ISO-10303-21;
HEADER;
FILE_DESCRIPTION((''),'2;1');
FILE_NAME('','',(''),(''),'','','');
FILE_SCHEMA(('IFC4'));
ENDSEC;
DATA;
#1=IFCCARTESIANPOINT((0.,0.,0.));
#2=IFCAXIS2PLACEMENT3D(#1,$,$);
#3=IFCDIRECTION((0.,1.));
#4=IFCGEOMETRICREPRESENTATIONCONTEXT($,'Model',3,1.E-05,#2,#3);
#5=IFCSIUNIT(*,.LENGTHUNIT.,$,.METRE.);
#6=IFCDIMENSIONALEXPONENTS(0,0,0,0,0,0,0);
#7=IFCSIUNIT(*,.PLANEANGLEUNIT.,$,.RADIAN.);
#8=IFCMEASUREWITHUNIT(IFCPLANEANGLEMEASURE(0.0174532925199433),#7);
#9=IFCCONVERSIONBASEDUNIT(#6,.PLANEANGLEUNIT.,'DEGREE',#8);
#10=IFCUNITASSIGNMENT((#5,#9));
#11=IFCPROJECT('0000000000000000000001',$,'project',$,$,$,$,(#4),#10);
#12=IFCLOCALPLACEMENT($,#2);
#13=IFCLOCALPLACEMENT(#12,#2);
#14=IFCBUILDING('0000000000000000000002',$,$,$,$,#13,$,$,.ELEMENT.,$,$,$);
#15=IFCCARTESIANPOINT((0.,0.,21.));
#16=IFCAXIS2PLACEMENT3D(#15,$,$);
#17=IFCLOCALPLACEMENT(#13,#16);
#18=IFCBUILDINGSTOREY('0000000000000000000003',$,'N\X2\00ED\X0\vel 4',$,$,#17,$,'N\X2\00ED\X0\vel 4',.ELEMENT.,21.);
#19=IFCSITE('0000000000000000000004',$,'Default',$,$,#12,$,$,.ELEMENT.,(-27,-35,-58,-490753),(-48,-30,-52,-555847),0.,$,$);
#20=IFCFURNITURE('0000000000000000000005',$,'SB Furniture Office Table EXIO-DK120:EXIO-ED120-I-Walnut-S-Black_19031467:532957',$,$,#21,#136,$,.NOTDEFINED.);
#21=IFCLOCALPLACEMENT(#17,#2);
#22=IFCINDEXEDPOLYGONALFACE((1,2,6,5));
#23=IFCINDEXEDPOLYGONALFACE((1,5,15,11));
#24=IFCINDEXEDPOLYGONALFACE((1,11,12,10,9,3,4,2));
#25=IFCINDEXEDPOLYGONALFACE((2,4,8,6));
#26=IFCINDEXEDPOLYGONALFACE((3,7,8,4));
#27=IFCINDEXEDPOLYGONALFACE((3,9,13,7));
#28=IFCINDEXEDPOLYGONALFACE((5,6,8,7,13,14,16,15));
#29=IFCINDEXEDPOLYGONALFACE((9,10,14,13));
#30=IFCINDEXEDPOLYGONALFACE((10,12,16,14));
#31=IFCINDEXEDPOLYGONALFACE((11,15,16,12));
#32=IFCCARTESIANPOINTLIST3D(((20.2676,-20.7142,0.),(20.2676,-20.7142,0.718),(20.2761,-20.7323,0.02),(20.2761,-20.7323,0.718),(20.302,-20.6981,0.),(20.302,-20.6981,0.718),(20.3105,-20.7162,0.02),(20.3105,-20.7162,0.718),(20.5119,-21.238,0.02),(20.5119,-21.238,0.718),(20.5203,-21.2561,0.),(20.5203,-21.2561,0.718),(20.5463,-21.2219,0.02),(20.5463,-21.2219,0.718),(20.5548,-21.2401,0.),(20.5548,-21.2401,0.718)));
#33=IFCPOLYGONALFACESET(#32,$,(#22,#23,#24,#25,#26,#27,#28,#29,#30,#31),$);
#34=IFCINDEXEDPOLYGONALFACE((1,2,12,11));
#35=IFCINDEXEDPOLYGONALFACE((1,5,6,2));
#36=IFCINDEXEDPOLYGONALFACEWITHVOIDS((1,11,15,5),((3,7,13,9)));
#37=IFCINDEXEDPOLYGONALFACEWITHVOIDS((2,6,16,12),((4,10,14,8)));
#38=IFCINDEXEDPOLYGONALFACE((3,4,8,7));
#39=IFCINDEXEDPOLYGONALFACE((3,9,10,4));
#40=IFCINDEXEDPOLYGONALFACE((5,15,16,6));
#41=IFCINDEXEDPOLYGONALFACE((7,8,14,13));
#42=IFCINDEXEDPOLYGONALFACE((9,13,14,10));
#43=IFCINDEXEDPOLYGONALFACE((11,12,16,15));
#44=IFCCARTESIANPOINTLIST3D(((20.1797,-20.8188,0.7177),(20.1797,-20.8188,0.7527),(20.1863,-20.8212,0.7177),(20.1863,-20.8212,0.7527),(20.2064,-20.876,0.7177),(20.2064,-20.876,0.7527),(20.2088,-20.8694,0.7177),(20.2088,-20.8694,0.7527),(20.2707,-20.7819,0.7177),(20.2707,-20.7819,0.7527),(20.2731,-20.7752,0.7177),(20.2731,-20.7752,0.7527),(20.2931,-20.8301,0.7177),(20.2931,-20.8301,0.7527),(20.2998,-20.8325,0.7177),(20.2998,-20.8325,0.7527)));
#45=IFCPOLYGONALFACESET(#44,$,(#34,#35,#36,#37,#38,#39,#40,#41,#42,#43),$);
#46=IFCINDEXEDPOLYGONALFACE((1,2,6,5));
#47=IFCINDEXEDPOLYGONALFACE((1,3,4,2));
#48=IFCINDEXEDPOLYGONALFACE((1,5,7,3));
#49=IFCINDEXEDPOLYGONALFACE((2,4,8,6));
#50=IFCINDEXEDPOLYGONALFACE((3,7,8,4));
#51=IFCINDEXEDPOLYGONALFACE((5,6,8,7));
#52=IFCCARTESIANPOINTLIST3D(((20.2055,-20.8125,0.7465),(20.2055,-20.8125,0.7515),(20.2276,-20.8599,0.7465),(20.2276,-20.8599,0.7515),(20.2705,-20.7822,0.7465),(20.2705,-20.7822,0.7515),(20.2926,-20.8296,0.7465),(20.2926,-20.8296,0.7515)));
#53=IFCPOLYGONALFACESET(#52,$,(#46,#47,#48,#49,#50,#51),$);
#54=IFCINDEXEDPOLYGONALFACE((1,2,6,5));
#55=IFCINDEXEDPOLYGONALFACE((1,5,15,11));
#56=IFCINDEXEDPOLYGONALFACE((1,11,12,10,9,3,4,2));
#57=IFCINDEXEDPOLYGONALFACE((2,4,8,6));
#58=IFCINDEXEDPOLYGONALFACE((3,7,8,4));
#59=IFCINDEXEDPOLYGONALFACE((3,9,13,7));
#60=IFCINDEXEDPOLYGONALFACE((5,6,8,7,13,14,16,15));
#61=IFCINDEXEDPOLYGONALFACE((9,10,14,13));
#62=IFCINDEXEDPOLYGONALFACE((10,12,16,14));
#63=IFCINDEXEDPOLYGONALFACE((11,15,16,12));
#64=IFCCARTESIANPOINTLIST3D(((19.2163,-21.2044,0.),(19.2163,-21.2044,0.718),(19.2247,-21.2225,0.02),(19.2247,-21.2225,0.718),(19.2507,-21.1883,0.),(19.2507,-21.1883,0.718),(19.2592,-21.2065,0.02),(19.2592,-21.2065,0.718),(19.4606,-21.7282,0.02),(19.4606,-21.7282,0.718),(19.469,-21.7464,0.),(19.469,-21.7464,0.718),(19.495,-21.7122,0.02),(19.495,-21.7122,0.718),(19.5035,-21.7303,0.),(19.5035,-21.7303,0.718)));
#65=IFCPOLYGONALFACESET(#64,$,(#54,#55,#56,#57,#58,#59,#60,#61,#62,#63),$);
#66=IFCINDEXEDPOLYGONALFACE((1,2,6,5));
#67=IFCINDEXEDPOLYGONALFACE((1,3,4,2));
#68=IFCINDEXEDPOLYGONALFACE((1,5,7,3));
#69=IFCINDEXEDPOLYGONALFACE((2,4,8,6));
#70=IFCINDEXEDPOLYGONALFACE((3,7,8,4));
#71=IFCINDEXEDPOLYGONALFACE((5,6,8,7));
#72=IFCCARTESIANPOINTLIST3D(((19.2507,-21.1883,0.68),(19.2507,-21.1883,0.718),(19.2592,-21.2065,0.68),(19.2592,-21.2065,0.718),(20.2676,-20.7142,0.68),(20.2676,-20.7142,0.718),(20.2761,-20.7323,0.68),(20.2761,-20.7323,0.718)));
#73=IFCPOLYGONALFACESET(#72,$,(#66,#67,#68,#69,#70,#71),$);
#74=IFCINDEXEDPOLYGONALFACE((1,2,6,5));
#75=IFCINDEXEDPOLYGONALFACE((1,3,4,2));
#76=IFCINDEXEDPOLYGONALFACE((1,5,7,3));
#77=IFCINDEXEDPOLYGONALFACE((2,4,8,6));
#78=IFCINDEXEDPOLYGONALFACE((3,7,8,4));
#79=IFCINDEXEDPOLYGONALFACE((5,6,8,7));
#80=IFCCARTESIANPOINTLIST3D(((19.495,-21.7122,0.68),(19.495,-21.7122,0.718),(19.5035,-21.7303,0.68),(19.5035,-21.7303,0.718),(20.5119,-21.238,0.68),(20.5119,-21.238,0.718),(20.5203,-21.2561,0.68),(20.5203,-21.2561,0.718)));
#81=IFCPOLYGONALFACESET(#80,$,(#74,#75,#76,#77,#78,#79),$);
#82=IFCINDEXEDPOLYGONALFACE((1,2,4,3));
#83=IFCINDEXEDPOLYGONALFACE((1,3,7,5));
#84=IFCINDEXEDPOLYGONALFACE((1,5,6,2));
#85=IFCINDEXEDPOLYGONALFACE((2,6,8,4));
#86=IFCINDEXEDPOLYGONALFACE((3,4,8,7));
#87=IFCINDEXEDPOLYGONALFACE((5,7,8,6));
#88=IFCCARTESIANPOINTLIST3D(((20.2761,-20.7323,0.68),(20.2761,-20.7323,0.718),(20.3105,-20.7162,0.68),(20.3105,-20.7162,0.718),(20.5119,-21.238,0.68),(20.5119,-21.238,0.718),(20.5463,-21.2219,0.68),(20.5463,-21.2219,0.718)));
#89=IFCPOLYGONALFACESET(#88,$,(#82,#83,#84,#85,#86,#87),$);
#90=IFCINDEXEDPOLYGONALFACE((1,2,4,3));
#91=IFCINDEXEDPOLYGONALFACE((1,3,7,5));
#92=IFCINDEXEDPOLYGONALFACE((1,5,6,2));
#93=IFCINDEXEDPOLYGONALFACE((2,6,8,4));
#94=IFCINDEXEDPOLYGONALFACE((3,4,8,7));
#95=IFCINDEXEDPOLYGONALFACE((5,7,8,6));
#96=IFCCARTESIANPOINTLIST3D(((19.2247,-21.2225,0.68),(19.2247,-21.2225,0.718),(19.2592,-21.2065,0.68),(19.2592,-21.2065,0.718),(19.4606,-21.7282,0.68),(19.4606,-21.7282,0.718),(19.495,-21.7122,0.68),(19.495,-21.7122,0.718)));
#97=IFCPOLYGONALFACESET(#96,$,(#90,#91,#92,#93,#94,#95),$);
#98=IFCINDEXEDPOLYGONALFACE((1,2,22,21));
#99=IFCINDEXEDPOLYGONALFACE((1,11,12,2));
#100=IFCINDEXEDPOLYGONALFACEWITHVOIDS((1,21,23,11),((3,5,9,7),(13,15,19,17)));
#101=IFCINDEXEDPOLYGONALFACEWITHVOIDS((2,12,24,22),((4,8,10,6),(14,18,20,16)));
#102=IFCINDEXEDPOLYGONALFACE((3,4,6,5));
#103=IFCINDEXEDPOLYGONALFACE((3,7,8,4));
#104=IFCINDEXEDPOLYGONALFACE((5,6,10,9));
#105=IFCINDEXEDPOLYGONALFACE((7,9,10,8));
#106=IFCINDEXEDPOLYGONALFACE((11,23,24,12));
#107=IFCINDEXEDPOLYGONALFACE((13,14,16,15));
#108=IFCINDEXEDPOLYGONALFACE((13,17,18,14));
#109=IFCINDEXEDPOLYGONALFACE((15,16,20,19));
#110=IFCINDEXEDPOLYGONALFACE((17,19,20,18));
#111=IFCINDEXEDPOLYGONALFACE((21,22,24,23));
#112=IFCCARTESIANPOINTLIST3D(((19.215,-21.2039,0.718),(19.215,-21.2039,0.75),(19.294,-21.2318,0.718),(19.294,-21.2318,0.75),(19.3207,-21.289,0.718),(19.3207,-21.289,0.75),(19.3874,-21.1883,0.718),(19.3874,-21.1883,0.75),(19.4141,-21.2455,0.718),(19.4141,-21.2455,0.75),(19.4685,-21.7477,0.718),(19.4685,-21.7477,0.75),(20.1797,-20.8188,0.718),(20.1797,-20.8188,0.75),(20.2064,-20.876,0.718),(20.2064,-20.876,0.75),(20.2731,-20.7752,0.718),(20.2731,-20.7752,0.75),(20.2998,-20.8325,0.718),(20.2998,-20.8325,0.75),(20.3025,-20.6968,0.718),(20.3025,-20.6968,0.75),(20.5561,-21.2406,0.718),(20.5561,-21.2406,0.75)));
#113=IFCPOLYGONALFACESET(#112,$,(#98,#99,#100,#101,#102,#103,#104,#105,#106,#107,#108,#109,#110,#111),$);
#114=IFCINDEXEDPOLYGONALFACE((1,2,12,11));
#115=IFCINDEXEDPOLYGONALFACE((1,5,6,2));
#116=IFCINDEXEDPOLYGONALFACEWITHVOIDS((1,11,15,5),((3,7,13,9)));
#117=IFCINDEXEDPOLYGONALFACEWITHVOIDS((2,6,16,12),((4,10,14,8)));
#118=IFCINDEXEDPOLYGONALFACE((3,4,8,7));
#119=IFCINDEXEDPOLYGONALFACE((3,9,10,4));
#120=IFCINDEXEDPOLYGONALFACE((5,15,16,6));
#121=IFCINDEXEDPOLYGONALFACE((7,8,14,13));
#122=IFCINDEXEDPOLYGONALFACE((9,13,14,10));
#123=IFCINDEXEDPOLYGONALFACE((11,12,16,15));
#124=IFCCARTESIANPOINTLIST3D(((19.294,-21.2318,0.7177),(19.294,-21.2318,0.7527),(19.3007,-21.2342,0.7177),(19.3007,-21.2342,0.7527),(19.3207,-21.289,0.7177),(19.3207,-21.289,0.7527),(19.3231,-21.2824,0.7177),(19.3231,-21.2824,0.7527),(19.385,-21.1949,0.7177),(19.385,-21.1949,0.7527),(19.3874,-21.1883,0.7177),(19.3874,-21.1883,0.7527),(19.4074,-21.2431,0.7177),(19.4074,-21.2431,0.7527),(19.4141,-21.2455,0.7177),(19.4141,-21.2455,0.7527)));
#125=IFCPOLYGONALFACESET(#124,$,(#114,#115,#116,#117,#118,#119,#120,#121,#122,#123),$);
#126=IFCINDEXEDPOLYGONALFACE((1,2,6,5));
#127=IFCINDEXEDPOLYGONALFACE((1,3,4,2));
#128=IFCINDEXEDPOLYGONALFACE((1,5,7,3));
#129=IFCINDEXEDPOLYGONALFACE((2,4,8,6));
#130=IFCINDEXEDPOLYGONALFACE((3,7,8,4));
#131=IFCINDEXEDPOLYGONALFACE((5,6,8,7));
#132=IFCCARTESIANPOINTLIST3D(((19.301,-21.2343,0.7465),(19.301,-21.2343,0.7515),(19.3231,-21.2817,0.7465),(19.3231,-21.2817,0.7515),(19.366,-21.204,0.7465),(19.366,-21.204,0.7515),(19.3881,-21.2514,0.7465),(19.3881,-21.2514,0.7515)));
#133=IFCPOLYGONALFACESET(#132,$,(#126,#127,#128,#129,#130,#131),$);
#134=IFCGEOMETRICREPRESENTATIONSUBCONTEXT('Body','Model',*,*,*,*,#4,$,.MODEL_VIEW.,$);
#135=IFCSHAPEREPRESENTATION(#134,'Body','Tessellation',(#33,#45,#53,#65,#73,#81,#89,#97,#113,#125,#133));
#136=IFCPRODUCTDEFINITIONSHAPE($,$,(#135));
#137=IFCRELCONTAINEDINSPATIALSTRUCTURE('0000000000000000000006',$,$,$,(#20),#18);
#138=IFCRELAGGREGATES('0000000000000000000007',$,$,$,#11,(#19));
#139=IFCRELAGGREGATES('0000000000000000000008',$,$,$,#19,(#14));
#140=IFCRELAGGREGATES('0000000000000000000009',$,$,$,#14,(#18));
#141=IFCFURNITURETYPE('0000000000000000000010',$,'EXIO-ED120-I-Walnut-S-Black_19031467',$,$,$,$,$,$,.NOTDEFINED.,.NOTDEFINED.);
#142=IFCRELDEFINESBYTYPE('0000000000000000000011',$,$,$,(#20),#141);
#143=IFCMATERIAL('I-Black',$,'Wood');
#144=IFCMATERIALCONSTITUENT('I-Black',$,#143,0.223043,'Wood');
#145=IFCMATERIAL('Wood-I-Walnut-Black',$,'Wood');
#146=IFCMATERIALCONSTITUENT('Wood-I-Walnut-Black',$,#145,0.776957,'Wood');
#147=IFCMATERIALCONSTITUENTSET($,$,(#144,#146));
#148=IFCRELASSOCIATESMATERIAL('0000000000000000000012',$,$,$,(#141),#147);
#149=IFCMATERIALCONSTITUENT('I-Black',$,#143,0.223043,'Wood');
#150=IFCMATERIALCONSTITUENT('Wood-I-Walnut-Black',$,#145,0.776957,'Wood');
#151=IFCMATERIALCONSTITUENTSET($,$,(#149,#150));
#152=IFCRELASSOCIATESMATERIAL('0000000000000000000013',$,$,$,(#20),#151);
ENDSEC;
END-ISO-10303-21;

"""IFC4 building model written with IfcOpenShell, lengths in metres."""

from ifc_helpers import new_model, entity, si_unit, converted_unit, direction, frame, frame_2d, origin, origin_2d_with_axis, place, context, subcontext, project, spatial, polyline, rectangle, outline, extrude, source, transform, mapped, material, constituent, constituent_set, type_object, type_shapes, element, save


model = new_model("IFC4")

# Units and contexts
model_context = context("Model", 3, precision=1e-05, world=origin(), true_north=direction((0.0, 1.0)))
body_context = subcontext(model_context, "Body", "Model", "MODEL_VIEW")
ifc_project = project(units=[si_unit("LENGTHUNIT", "METRE"), converted_unit("PLANEANGLEUNIT", "DEGREE", entity("IfcPlaneAngleMeasure", 0.0174532925199433), si_unit("PLANEANGLEUNIT", "RADIAN"), dimensions=[0, 0, 0, 0, 0, 0, 0])], contexts=[model_context])

# Site, building, storey
site_placement = place(None, origin())
site = spatial("IfcSite", under=ifc_project, at=site_placement, Name="Default", CompositionType="ELEMENT", RefLatitude=(-27, -35, -58, -490753), RefLongitude=(-48, -30, -52, -555847), RefElevation=0.0)
building_placement = place(site_placement, origin())
building = spatial("IfcBuilding", under=site, at=building_placement, CompositionType="ELEMENT")
storey_placement = place(building_placement, frame((0.0, 0.0, 21.0)))
storey = spatial("IfcBuildingStorey", under=building, at=storey_placement, Name="Nível 4", LongName="Nível 4", CompositionType="ELEMENT", Elevation=21.0)

# Furniture
ifc_material_1 = material(Name="I-Black", Category="Wood")
ifc_constituent_1 = constituent(ifc_material_1, Name="I-Black", Category="Wood", fraction=0.223043)
ifc_material_2 = material(Name="Wood-I-Walnut-Black", Category="Wood")
ifc_constituent_2 = constituent(ifc_material_2, Name="Wood-I-Walnut-Black", Category="Wood", fraction=0.776957)
ifc_constituent_set_1 = constituent_set(constituents=[ifc_constituent_1, ifc_constituent_2])
ifc_constituent_3 = constituent(ifc_material_1, Name="I-Black", Category="Wood", fraction=0.223043)
ifc_constituent_4 = constituent(ifc_material_2, Name="Wood-I-Walnut-Black", Category="Wood", fraction=0.776957)
ifc_constituent_set_2 = constituent_set(constituents=[ifc_constituent_3, ifc_constituent_4])
furniture_type = type_object("IfcFurnitureType", Name="EXIO-ED120-I-Walnut-S-Black_19031467", AssemblyPlace="NOTDEFINED", PredefinedType="NOTDEFINED", material=ifc_constituent_set_2)
shared_shape_1 = source(origin(), body_context, "Body", "SweptSolid", [
    extrude(outline(polyline([(-0.354, -0.279), (-0.354, -0.299), (0.364, -0.299), (0.364, 0.299), (-0.354, 0.299), (-0.354, 0.279), (0.344, 0.279), (0.344, -0.279), (-0.354, -0.279)])), frame((0.561, 0.0, 0.364), z_axis=(-1.0, 0.0, 0.0), x_axis=(0.0, 0.0, -1.0)), (0.0, 0.0, -1.0), 0.038),
    extrude(outline(polyline([(-0.0316, -0.0515), (0.0316, -0.0515), (0.0316, 0.0515), (-0.0316, 0.0515), (-0.0316, -0.0515)]), holes=[polyline([(0.0266, -0.0465), (-0.0266, -0.0465), (-0.0266, 0.0465), (0.0266, 0.0465), (0.0266, -0.0465)])]), frame((0.4886, 0.2097, 0.7177), z_axis=(0.0, 0.0, 1.0), x_axis=(0.0, -1.0, 0.0)), (0.0, 0.0, 1.0), 0.035),
    extrude(rectangle(XDim=0.0717, YDim=0.0523, at=origin_2d_with_axis()), frame((0.499, 0.2099, 0.7465), z_axis=(0.0, 0.0, 1.0), x_axis=(-1.0, 0.0, 0.0)), (0.0, 0.0, 1.0), 0.005),
    extrude(outline(polyline([(-0.354, -0.279), (-0.354, -0.299), (0.364, -0.299), (0.364, 0.299), (-0.354, 0.299), (-0.354, 0.279), (0.344, 0.279), (0.344, -0.279), (-0.354, -0.279)])), frame((-0.599, 0.0, 0.364), z_axis=(-1.0, 0.0, 0.0), x_axis=(0.0, 0.0, -1.0)), (0.0, 0.0, -1.0), 0.038),
    extrude(rectangle(XDim=1.122, YDim=0.02, at=frame_2d((0.0, 0.0), x_axis=(1.0, 0.0))), frame((0.0, 0.289, 0.68), z_axis=(0.0, 0.0, 1.0), x_axis=(-1.0, 0.0, 0.0)), (0.0, 0.0, 1.0), 0.038),
    extrude(rectangle(XDim=1.122, YDim=0.02, at=origin_2d_with_axis()), frame((0.0, -0.289, 0.68), z_axis=(0.0, 0.0, 1.0), x_axis=(-1.0, 0.0, 0.0)), (0.0, 0.0, 1.0), 0.038),
    extrude(rectangle(XDim=0.038, YDim=0.558, at=frame_2d((0.0, 0.0), x_axis=(1.0, 0.0))), frame((0.58, 0.0, 0.68), z_axis=(0.0, 0.0, 1.0), x_axis=(-1.0, 0.0, 0.0)), (0.0, 0.0, 1.0), 0.038),
    extrude(rectangle(XDim=0.038, YDim=0.558, at=origin_2d_with_axis()), frame((-0.58, 0.0, 0.68), z_axis=(0.0, 0.0, 1.0), x_axis=(-1.0, 0.0, 0.0)), (0.0, 0.0, 1.0), 0.038),
    extrude(outline(polyline([(-0.6, -0.3), (0.6, -0.3), (0.6, 0.3), (-0.6, 0.3), (-0.6, -0.3)]), holes=[polyline([(0.4371, -0.2413), (0.4371, -0.1782), (0.5401, -0.1782), (0.5401, -0.2413), (0.4371, -0.2413)]), polyline([(-0.5401, -0.2413), (-0.5401, -0.1782), (-0.4371, -0.1782), (-0.4371, -0.2413), (-0.5401, -0.2413)])]), frame((0.0, 0.0, 0.718), z_axis=(0.0, 0.0, 1.0), x_axis=(-1.0, 0.0, 0.0)), (0.0, 0.0, 1.0), 0.032),
    extrude(outline(polyline([(-0.0316, -0.0515), (0.0316, -0.0515), (0.0316, 0.0515), (-0.0316, 0.0515), (-0.0316, -0.0515)]), holes=[polyline([(0.0266, -0.0465), (-0.0266, -0.0465), (-0.0266, 0.0465), (0.0266, 0.0465), (0.0266, -0.0465)])]), frame((-0.4886, 0.2097, 0.7177), z_axis=(0.0, 0.0, 1.0), x_axis=(0.0, 1.0, 0.0)), (0.0, 0.0, 1.0), 0.035),
    extrude(rectangle(XDim=0.0523, YDim=0.0717, at=origin_2d_with_axis()), frame((-0.499, 0.2099, 0.7465), z_axis=(0.0, 0.0, 1.0), x_axis=(0.0, -1.0, 0.0)), (0.0, 0.0, 1.0), 0.005),
])
type_shapes(furniture_type, [shared_shape_1])
furniture_1_placement = place(storey_placement, frame((19.8855, -21.2222, 0.0), z_axis=(0.0, 0.0, 1.0), x_axis=(0.906308, 0.422618, 0.0)))
element("IfcFurniture", 1, at=furniture_1_placement, inside=storey, type_object=furniture_type, material=ifc_constituent_set_1, Name="SB Furniture Office Table EXIO-DK120:EXIO-ED120-I-Walnut-S-Black_19031467:532957", PredefinedType="NOTDEFINED", context=body_context, shape_type="MappedRepresentation", body=[
    mapped(shared_shape_1, transform((0.0, 0.0, 0.0), scale=1.0)),
])

save(model, "model.ifc")
